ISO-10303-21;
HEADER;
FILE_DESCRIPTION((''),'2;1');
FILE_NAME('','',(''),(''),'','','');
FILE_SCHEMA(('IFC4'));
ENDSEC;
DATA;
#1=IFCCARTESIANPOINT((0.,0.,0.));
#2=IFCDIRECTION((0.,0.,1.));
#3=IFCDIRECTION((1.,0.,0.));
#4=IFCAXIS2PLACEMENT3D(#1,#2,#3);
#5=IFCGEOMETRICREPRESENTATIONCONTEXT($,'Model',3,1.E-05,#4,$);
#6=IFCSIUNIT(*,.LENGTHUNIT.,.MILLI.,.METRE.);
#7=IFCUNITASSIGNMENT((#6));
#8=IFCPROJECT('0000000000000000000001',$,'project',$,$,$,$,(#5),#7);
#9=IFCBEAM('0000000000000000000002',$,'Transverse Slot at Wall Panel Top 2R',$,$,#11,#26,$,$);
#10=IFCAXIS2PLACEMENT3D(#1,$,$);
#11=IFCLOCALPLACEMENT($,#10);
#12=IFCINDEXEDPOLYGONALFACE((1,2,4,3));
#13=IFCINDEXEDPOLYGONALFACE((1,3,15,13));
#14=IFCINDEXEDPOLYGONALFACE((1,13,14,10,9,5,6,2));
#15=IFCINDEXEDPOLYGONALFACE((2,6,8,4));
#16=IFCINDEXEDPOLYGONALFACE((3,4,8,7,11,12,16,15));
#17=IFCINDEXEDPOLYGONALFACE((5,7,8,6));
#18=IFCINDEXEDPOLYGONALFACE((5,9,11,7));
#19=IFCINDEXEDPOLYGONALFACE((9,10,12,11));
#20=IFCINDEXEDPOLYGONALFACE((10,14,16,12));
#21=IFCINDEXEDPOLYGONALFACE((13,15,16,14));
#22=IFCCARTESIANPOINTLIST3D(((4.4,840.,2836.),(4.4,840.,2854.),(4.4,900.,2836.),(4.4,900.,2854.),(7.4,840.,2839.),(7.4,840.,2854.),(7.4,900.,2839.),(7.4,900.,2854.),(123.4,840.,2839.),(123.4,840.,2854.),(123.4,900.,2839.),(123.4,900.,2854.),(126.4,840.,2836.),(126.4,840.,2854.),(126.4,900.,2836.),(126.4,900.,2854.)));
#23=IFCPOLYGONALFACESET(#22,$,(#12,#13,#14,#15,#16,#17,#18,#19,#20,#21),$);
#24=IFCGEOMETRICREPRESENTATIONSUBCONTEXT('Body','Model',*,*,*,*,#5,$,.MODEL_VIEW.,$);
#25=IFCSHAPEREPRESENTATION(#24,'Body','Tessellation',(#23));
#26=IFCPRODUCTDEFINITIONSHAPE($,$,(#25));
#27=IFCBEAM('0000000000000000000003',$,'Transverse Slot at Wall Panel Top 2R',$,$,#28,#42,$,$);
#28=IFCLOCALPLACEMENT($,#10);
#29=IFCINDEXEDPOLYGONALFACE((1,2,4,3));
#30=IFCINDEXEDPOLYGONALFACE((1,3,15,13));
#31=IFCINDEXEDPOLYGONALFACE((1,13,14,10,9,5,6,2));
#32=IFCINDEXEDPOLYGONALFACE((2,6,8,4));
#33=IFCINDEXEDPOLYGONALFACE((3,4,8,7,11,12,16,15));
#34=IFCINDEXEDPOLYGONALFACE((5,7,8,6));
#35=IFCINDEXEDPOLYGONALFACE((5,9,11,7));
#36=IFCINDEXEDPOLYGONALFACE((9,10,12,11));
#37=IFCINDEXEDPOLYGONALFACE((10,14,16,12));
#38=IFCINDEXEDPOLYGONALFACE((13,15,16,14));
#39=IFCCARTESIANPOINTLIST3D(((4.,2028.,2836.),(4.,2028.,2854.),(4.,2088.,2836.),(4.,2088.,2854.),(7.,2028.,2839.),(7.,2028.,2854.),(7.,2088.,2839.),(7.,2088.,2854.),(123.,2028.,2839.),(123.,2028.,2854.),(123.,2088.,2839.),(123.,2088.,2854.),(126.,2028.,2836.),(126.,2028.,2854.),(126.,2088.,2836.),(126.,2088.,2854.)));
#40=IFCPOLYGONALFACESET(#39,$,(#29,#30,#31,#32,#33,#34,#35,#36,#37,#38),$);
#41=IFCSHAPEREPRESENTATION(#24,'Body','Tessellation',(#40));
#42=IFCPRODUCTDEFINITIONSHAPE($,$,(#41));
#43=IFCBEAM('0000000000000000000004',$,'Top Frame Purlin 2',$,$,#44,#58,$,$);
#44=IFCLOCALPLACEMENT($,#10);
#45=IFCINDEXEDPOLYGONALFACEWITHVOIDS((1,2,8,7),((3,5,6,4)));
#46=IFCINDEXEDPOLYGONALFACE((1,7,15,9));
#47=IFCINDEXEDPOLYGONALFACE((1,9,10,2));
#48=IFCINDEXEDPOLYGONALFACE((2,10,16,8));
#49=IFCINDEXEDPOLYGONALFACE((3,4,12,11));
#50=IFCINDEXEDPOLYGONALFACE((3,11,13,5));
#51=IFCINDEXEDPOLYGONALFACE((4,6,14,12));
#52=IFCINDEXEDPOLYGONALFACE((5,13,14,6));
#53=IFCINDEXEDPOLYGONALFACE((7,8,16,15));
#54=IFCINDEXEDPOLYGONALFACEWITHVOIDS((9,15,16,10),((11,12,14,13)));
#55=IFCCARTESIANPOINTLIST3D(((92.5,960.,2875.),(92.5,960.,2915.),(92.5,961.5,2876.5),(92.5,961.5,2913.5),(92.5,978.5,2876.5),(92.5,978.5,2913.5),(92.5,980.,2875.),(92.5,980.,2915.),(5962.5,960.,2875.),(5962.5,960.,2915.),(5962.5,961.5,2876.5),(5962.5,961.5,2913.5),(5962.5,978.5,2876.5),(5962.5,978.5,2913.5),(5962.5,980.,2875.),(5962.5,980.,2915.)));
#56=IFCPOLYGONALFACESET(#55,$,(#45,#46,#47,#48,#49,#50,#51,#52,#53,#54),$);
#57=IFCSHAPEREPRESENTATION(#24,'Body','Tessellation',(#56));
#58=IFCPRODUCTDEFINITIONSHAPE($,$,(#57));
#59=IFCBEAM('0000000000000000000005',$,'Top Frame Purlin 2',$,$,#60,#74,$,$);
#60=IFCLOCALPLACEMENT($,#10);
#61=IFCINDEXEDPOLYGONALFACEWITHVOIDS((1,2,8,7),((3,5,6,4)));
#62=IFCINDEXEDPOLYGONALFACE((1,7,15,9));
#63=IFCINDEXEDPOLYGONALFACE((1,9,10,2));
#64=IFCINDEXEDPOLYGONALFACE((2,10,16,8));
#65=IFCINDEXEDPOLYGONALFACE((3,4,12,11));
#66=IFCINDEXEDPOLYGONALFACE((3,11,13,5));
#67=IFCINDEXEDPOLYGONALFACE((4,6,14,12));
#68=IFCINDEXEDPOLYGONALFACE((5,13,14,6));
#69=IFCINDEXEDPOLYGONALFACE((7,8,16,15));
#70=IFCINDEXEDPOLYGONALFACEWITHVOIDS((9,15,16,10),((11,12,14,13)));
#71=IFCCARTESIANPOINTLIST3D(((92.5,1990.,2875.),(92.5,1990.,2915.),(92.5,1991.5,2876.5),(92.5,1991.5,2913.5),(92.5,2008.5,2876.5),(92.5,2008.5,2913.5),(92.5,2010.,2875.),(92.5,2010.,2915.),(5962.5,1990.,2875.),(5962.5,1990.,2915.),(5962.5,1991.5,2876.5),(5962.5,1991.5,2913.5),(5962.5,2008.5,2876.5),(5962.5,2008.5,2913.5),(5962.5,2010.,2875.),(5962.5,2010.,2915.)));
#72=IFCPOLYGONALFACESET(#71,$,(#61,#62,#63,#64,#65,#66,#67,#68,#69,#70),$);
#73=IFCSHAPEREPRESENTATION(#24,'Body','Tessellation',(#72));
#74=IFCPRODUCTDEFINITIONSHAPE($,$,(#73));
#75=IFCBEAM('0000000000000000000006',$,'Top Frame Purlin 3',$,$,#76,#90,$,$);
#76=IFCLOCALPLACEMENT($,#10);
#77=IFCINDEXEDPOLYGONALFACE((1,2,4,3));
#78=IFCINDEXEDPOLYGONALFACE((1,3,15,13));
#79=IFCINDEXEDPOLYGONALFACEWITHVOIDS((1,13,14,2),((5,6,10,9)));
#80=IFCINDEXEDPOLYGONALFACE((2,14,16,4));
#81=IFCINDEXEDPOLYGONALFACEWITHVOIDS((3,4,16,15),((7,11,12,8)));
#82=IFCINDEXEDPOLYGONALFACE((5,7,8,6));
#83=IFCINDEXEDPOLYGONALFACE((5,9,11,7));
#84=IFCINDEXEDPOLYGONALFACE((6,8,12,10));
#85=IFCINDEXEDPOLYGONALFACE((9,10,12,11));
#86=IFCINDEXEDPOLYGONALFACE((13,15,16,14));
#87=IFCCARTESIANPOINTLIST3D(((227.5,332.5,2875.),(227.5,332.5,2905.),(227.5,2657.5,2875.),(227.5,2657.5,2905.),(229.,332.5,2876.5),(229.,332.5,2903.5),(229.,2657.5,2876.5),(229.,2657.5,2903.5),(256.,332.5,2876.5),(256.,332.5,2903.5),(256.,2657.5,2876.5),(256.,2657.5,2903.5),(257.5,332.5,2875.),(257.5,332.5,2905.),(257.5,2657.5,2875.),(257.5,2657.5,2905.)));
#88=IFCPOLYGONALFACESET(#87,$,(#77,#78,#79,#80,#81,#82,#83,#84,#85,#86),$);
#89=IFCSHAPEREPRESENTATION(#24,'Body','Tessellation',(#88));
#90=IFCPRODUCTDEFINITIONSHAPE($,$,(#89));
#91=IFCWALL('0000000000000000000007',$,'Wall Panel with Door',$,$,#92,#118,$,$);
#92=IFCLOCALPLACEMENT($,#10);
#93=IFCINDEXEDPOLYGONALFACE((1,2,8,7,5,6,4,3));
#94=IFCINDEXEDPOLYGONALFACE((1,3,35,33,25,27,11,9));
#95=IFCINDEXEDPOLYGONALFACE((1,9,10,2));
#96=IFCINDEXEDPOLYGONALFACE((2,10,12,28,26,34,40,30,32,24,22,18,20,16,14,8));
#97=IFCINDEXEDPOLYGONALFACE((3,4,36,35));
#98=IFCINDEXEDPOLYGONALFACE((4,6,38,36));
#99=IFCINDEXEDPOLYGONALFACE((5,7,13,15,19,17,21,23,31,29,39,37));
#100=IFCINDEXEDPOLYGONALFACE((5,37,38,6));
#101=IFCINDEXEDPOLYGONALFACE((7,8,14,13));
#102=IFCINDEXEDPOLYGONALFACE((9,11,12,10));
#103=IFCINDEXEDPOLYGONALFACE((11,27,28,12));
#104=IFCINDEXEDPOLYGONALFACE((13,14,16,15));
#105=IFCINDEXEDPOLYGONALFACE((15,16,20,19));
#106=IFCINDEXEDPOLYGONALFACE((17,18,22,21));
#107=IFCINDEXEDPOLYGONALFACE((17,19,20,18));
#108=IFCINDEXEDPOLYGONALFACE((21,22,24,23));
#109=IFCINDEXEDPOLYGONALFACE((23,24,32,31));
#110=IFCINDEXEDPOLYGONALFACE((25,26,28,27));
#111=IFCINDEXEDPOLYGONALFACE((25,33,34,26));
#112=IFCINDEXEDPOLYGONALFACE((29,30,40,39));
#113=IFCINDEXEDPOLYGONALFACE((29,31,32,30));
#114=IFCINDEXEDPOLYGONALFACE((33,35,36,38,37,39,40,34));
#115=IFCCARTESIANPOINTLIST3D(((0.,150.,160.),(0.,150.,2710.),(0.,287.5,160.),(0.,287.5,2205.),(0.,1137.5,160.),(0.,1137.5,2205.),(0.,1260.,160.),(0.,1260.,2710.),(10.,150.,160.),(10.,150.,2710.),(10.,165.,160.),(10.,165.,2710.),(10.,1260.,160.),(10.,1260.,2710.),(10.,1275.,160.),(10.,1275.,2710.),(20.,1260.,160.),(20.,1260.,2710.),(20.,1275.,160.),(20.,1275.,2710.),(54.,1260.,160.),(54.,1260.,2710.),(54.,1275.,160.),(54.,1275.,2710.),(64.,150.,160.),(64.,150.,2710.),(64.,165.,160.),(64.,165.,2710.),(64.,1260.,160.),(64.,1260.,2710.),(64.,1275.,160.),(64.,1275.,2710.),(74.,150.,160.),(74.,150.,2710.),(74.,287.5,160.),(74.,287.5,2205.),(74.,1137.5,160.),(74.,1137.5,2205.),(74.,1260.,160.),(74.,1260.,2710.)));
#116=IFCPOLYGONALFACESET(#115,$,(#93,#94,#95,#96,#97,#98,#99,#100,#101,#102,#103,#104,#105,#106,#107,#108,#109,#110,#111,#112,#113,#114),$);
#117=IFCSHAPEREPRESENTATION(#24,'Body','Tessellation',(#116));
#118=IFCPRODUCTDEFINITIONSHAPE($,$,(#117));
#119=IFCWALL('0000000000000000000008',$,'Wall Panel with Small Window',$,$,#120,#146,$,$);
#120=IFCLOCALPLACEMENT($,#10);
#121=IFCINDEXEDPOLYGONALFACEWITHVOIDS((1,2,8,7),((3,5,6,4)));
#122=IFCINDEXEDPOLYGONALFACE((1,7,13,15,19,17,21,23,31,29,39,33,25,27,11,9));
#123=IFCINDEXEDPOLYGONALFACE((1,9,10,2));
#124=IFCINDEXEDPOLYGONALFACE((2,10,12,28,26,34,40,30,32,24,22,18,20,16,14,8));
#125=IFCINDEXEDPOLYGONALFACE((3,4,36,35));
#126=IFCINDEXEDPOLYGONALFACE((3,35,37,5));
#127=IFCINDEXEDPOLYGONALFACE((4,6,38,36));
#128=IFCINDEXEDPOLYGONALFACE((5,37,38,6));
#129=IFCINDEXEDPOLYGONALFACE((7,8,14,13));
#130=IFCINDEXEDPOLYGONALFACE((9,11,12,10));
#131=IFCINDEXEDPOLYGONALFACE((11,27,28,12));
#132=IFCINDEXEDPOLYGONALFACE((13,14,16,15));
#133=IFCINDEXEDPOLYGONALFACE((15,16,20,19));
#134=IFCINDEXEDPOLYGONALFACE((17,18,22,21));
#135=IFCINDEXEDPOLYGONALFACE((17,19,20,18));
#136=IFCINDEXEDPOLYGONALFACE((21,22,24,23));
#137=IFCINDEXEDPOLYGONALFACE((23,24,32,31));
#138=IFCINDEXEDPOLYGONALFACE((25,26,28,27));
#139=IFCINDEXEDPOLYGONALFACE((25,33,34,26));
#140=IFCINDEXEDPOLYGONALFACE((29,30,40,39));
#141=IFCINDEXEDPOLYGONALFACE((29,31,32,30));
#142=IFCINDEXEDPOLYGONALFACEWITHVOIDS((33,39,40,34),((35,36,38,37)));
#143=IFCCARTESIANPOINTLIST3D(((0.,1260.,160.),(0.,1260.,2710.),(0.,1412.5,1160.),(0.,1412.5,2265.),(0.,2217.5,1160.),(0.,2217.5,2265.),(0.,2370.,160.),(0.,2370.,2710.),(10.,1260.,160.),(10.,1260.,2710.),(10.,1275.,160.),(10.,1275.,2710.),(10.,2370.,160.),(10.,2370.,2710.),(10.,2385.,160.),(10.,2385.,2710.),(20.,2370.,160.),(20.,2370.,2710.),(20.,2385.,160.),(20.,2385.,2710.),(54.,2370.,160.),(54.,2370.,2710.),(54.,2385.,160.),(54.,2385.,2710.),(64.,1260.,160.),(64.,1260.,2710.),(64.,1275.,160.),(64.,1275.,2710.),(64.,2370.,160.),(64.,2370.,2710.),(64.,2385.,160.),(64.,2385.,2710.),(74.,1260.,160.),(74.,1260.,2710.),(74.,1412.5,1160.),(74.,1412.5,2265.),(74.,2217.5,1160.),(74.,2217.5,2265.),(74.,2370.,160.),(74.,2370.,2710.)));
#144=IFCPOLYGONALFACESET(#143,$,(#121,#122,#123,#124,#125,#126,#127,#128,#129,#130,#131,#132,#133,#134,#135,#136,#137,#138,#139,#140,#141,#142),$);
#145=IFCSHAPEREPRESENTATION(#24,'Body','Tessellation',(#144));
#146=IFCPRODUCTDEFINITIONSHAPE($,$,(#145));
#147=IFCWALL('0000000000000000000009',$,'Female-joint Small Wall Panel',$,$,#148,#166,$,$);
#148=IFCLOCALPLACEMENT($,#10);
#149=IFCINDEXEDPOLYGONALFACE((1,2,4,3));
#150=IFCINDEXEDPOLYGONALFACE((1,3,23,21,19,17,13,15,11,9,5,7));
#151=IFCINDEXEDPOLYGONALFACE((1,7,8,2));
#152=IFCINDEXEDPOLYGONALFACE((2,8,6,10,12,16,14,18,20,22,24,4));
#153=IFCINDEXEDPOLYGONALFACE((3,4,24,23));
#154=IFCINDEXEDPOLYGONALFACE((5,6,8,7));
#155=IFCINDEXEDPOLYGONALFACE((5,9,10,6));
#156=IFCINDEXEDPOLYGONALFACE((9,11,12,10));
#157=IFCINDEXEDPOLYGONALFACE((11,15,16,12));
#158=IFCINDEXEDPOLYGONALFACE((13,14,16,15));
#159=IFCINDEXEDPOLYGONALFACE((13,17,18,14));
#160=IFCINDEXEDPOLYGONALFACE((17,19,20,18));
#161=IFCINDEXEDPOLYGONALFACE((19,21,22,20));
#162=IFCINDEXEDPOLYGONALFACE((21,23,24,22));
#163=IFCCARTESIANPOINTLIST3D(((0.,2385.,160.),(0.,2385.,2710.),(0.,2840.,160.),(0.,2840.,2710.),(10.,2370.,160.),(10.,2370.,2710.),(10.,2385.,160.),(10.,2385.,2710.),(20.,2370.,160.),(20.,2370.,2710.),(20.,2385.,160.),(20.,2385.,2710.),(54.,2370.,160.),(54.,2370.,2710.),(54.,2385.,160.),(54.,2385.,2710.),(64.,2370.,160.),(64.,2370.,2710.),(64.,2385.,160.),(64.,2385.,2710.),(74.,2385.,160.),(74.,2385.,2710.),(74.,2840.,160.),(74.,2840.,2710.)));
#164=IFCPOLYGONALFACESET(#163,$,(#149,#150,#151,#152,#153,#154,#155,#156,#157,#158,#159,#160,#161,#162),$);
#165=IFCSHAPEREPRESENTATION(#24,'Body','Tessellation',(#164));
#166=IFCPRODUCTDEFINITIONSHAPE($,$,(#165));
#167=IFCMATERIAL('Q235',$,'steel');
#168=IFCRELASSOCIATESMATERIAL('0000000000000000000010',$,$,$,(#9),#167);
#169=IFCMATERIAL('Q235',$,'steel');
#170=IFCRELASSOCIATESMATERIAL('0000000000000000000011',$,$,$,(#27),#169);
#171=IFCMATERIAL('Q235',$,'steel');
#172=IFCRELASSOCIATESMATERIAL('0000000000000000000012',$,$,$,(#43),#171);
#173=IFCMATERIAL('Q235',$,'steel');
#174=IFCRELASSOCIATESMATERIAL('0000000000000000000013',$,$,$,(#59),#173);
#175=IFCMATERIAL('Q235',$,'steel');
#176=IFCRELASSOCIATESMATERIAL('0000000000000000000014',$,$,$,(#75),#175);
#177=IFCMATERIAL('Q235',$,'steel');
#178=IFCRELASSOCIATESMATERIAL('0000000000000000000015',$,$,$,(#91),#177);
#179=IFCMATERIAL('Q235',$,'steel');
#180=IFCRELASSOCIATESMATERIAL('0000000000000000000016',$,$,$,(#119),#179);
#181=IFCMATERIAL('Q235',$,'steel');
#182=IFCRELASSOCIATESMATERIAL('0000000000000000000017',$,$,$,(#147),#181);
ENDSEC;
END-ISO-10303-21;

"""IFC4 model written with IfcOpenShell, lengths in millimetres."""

from ifc_helpers import new_model, si_unit, frame, origin_with_axes, place, context, subcontext, project, line, indexed_curve, outline, extrude, material, element, save


model = new_model("IFC4")

# Units and contexts
model_context = context("Model", 3, precision=1e-05, world=origin_with_axes())
body_context = subcontext(model_context, "Body", "Model", "MODEL_VIEW")
ifc_project = project(units=[si_unit("LENGTHUNIT", "METRE", prefix="MILLI")], contexts=[model_context])

# Beams
ifc_material_1 = material(Name="Q235", Category="steel")
beam_1_placement = place(None, frame((4.4, 840.0, 2836.0), z_axis=(0.0, 1.0, 0.0), x_axis=(0.0, 0.0, 1.0)))
element("IfcBeam", 1, at=beam_1_placement, material=ifc_material_1, Name="Transverse Slot at Wall Panel Top 2R", context=body_context, shape_type="SweptSolid", body=[
    extrude(outline(indexed_curve([(0.0, 0.0), (0.0, 122.0), (18.0, 122.0), (18.0, 119.0), (3.0, 119.0), (3.0, 3.0), (18.0, 3.0), (18.0, 0.0), (0.0, 0.0)], segments=[line(1, 2, 3, 4, 5, 6, 7, 8, 9, 1)])), origin_with_axes(), (0.0, 0.0, 1.0), 60.0),
])
ifc_material_2 = material(Name="Q235", Category="steel")
beam_2_placement = place(None, frame((4.0, 2028.0, 2836.0), z_axis=(0.0, 1.0, 0.0), x_axis=(0.0, 0.0, 1.0)))
element("IfcBeam", 2, at=beam_2_placement, material=ifc_material_2, Name="Transverse Slot at Wall Panel Top 2R", context=body_context, shape_type="SweptSolid", body=[
    extrude(outline(indexed_curve([(0.0, 0.0), (0.0, 122.0), (18.0, 122.0), (18.0, 119.0), (3.0, 119.0), (3.0, 3.0), (18.0, 3.0), (18.0, 0.0), (0.0, 0.0)], segments=[line(1, 2, 3, 4, 5, 6, 7, 8, 9, 1)])), origin_with_axes(), (0.0, 0.0, 1.0), 60.0),
])

# Beams, openings
ifc_material_3 = material(Name="Q235", Category="steel")
beam_3_placement = place(None, frame((92.5, 960.0, 2875.0), z_axis=(1.0, 0.0, 0.0), x_axis=(0.0, 1.0, 0.0)))
beam_3 = element("IfcBeam", 3, at=beam_3_placement, material=ifc_material_3, Name="Top Frame Purlin 2", context=body_context, shape_type="SweptSolid", body=[
    extrude(outline(indexed_curve([(0.0, 0.0), (0.0, 40.0), (20.0, 40.0), (20.0, 0.0), (0.0, 0.0)], segments=[line(1, 2, 3, 4, 5, 1)])), origin_with_axes(), (0.0, 0.0, 1.0), 5870.0),
])
opening_1_placement = place(beam_3_placement, frame((1.5, 1.5, 0.0), z_axis=(0.0, 0.0, 1.0), x_axis=(1.0, 0.0, 0.0)))
element("IfcOpeningElement", 4, at=opening_1_placement, cuts=beam_3, context=body_context, shape_type="SweptSolid", body=[
    extrude(outline(indexed_curve([(0.0, 0.0), (0.0, 37.0), (17.0, 37.0), (17.0, 0.0)], segments=[line(1, 2, 3, 4, 1)])), origin_with_axes(), (0.0, 0.0, 1.0), 5870.0),
])
ifc_material_4 = material(Name="Q235", Category="steel")
beam_4_placement = place(None, frame((92.5, 1990.0, 2875.0), z_axis=(1.0, 0.0, 0.0), x_axis=(0.0, 1.0, 0.0)))
beam_4 = element("IfcBeam", 5, at=beam_4_placement, material=ifc_material_4, Name="Top Frame Purlin 2", context=body_context, shape_type="SweptSolid", body=[
    extrude(outline(indexed_curve([(0.0, 0.0), (0.0, 40.0), (20.0, 40.0), (20.0, 0.0), (0.0, 0.0)], segments=[line(1, 2, 3, 4, 5, 1)])), origin_with_axes(), (0.0, 0.0, 1.0), 5870.0),
])
opening_2_placement = place(beam_4_placement, frame((1.5, 1.5, 0.0), z_axis=(0.0, 0.0, 1.0), x_axis=(1.0, 0.0, 0.0)))
element("IfcOpeningElement", 6, at=opening_2_placement, cuts=beam_4, context=body_context, shape_type="SweptSolid", body=[
    extrude(outline(indexed_curve([(0.0, 0.0), (0.0, 37.0), (17.0, 37.0), (17.0, 0.0)], segments=[line(1, 2, 3, 4, 1)])), origin_with_axes(), (0.0, 0.0, 1.0), 5870.0),
])
ifc_material_5 = material(Name="Q235", Category="steel")
beam_5_placement = place(None, frame((227.5, 332.5, 2875.0), z_axis=(0.0, 1.0, 0.0), x_axis=(1.0, 0.0, 0.0)))
beam_5 = element("IfcBeam", 7, at=beam_5_placement, material=ifc_material_5, Name="Top Frame Purlin 3", context=body_context, shape_type="SweptSolid", body=[
    extrude(outline(indexed_curve([(0.0, 0.0), (0.0, -30.0), (30.0, -30.0), (30.0, 0.0), (0.0, 0.0)], segments=[line(1, 2, 3, 4, 5, 1)])), origin_with_axes(), (0.0, 0.0, 1.0), 2325.0),
])
opening_3_placement = place(beam_5_placement, frame((1.5, -1.5, 0.0), z_axis=(0.0, 0.0, 1.0), x_axis=(1.0, 0.0, 0.0)))
element("IfcOpeningElement", 8, at=opening_3_placement, cuts=beam_5, context=body_context, shape_type="SweptSolid", body=[
    extrude(outline(indexed_curve([(0.0, 0.0), (0.0, -27.0), (27.0, -27.0), (27.0, 0.0)], segments=[line(1, 2, 3, 4, 1)])), origin_with_axes(), (0.0, 0.0, 1.0), 2325.0),
])

# Walls, openings
ifc_material_6 = material(Name="Q235", Category="steel")
wall_1_placement = place(None, frame((74.0, 150.0, 160.0), z_axis=(0.0, 0.0, 1.0), x_axis=(0.0, 1.0, 0.0)))
wall_1 = element("IfcWall", 9, at=wall_1_placement, material=ifc_material_6, Name="Wall Panel with Door", context=body_context, shape_type="SweptSolid", body=[
    extrude(outline(indexed_curve([(0.0, 0.0), (0.0, 10.0), (15.0, 10.0), (15.0, 64.0), (0.0, 64.0), (0.0, 74.0), (1110.0, 74.0), (1110.0, 64.0), (1125.0, 64.0), (1125.0, 54.0), (1125.0, 54.0), (1110.0, 54.0), (1110.0, 20.0), (1125.0, 20.0), (1125.0, 10.0), (1110.0, 10.0), (1110.0, 0.0), (0.0, 0.0)], segments=[line(1, 2, 3, 4, 5, 6, 7, 8, 9, 10, 11, 12, 13, 14, 15, 16, 17, 18, 1)])), origin_with_axes(), (0.0, 0.0, 1.0), 2550.0),
])
opening_4_placement = place(wall_1_placement, frame((137.5, 0.0, 0.0), z_axis=(0.0, 0.0, 1.0), x_axis=(1.0, 0.0, 0.0)))
element("IfcOpeningElement", 10, at=opening_4_placement, cuts=wall_1, context=body_context, shape_type="SweptSolid", body=[
    extrude(outline(indexed_curve([(0.0, 0.0), (0.0, 74.0), (850.0, 74.0), (850.0, 0.0)], segments=[line(1, 2, 3, 4, 1)])), origin_with_axes(), (0.0, 0.0, 1.0), 2045.0),
])
ifc_material_7 = material(Name="Q235", Category="steel")
wall_2_placement = place(None, frame((74.0, 1260.0, 160.0), z_axis=(0.0, 0.0, 1.0), x_axis=(0.0, 1.0, 0.0)))
wall_2 = element("IfcWall", 11, at=wall_2_placement, material=ifc_material_7, Name="Wall Panel with Small Window", context=body_context, shape_type="SweptSolid", body=[
    extrude(outline(indexed_curve([(0.0, 0.0), (0.0, 10.0), (15.0, 10.0), (15.0, 64.0), (0.0, 64.0), (0.0, 74.0), (1110.0, 74.0), (1110.0, 64.0), (1125.0, 64.0), (1125.0, 54.0), (1125.0, 54.0), (1110.0, 54.0), (1110.0, 20.0), (1125.0, 20.0), (1125.0, 10.0), (1110.0, 10.0), (1110.0, 0.0), (0.0, 0.0)], segments=[line(1, 2, 3, 4, 5, 6, 7, 8, 9, 10, 11, 12, 13, 14, 15, 16, 17, 18, 1)])), origin_with_axes(), (0.0, 0.0, 1.0), 2550.0),
])
opening_5_placement = place(wall_2_placement, frame((152.5, 0.0, 1000.0), z_axis=(0.0, 0.0, 1.0), x_axis=(1.0, 0.0, 0.0)))
element("IfcOpeningElement", 12, at=opening_5_placement, cuts=wall_2, context=body_context, shape_type="SweptSolid", body=[
    extrude(outline(indexed_curve([(0.0, 0.0), (0.0, 74.0), (805.0, 74.0), (805.0, 0.0)], segments=[line(1, 2, 3, 4, 1)])), origin_with_axes(), (0.0, 0.0, 1.0), 1105.0),
])

# Wall
ifc_material_8 = material(Name="Q235", Category="steel")
wall_3_placement = place(None, frame((0.0, 2840.0, 160.0), z_axis=(0.0, 0.0, 1.0), x_axis=(0.0, -1.0, 0.0)))
element("IfcWall", 13, at=wall_3_placement, material=ifc_material_8, Name="Female-joint Small Wall Panel", context=body_context, shape_type="SweptSolid", body=[
    extrude(outline(indexed_curve([(0.0, 0.0), (0.0, 74.0), (455.0, 74.0), (455.0, 64.0), (470.0, 64.0), (470.0, 54.0), (455.0, 54.0), (455.0, 20.0), (470.0, 20.0), (470.0, 10.0), (455.0, 10.0), (455.0, 0.0), (0.0, 0.0)], segments=[line(1, 2, 3, 4, 5, 6, 7, 8, 9, 10, 11, 12, 13, 1)])), origin_with_axes(), (0.0, 0.0, 1.0), 2550.0),
])

save(model, "model.ifc")
